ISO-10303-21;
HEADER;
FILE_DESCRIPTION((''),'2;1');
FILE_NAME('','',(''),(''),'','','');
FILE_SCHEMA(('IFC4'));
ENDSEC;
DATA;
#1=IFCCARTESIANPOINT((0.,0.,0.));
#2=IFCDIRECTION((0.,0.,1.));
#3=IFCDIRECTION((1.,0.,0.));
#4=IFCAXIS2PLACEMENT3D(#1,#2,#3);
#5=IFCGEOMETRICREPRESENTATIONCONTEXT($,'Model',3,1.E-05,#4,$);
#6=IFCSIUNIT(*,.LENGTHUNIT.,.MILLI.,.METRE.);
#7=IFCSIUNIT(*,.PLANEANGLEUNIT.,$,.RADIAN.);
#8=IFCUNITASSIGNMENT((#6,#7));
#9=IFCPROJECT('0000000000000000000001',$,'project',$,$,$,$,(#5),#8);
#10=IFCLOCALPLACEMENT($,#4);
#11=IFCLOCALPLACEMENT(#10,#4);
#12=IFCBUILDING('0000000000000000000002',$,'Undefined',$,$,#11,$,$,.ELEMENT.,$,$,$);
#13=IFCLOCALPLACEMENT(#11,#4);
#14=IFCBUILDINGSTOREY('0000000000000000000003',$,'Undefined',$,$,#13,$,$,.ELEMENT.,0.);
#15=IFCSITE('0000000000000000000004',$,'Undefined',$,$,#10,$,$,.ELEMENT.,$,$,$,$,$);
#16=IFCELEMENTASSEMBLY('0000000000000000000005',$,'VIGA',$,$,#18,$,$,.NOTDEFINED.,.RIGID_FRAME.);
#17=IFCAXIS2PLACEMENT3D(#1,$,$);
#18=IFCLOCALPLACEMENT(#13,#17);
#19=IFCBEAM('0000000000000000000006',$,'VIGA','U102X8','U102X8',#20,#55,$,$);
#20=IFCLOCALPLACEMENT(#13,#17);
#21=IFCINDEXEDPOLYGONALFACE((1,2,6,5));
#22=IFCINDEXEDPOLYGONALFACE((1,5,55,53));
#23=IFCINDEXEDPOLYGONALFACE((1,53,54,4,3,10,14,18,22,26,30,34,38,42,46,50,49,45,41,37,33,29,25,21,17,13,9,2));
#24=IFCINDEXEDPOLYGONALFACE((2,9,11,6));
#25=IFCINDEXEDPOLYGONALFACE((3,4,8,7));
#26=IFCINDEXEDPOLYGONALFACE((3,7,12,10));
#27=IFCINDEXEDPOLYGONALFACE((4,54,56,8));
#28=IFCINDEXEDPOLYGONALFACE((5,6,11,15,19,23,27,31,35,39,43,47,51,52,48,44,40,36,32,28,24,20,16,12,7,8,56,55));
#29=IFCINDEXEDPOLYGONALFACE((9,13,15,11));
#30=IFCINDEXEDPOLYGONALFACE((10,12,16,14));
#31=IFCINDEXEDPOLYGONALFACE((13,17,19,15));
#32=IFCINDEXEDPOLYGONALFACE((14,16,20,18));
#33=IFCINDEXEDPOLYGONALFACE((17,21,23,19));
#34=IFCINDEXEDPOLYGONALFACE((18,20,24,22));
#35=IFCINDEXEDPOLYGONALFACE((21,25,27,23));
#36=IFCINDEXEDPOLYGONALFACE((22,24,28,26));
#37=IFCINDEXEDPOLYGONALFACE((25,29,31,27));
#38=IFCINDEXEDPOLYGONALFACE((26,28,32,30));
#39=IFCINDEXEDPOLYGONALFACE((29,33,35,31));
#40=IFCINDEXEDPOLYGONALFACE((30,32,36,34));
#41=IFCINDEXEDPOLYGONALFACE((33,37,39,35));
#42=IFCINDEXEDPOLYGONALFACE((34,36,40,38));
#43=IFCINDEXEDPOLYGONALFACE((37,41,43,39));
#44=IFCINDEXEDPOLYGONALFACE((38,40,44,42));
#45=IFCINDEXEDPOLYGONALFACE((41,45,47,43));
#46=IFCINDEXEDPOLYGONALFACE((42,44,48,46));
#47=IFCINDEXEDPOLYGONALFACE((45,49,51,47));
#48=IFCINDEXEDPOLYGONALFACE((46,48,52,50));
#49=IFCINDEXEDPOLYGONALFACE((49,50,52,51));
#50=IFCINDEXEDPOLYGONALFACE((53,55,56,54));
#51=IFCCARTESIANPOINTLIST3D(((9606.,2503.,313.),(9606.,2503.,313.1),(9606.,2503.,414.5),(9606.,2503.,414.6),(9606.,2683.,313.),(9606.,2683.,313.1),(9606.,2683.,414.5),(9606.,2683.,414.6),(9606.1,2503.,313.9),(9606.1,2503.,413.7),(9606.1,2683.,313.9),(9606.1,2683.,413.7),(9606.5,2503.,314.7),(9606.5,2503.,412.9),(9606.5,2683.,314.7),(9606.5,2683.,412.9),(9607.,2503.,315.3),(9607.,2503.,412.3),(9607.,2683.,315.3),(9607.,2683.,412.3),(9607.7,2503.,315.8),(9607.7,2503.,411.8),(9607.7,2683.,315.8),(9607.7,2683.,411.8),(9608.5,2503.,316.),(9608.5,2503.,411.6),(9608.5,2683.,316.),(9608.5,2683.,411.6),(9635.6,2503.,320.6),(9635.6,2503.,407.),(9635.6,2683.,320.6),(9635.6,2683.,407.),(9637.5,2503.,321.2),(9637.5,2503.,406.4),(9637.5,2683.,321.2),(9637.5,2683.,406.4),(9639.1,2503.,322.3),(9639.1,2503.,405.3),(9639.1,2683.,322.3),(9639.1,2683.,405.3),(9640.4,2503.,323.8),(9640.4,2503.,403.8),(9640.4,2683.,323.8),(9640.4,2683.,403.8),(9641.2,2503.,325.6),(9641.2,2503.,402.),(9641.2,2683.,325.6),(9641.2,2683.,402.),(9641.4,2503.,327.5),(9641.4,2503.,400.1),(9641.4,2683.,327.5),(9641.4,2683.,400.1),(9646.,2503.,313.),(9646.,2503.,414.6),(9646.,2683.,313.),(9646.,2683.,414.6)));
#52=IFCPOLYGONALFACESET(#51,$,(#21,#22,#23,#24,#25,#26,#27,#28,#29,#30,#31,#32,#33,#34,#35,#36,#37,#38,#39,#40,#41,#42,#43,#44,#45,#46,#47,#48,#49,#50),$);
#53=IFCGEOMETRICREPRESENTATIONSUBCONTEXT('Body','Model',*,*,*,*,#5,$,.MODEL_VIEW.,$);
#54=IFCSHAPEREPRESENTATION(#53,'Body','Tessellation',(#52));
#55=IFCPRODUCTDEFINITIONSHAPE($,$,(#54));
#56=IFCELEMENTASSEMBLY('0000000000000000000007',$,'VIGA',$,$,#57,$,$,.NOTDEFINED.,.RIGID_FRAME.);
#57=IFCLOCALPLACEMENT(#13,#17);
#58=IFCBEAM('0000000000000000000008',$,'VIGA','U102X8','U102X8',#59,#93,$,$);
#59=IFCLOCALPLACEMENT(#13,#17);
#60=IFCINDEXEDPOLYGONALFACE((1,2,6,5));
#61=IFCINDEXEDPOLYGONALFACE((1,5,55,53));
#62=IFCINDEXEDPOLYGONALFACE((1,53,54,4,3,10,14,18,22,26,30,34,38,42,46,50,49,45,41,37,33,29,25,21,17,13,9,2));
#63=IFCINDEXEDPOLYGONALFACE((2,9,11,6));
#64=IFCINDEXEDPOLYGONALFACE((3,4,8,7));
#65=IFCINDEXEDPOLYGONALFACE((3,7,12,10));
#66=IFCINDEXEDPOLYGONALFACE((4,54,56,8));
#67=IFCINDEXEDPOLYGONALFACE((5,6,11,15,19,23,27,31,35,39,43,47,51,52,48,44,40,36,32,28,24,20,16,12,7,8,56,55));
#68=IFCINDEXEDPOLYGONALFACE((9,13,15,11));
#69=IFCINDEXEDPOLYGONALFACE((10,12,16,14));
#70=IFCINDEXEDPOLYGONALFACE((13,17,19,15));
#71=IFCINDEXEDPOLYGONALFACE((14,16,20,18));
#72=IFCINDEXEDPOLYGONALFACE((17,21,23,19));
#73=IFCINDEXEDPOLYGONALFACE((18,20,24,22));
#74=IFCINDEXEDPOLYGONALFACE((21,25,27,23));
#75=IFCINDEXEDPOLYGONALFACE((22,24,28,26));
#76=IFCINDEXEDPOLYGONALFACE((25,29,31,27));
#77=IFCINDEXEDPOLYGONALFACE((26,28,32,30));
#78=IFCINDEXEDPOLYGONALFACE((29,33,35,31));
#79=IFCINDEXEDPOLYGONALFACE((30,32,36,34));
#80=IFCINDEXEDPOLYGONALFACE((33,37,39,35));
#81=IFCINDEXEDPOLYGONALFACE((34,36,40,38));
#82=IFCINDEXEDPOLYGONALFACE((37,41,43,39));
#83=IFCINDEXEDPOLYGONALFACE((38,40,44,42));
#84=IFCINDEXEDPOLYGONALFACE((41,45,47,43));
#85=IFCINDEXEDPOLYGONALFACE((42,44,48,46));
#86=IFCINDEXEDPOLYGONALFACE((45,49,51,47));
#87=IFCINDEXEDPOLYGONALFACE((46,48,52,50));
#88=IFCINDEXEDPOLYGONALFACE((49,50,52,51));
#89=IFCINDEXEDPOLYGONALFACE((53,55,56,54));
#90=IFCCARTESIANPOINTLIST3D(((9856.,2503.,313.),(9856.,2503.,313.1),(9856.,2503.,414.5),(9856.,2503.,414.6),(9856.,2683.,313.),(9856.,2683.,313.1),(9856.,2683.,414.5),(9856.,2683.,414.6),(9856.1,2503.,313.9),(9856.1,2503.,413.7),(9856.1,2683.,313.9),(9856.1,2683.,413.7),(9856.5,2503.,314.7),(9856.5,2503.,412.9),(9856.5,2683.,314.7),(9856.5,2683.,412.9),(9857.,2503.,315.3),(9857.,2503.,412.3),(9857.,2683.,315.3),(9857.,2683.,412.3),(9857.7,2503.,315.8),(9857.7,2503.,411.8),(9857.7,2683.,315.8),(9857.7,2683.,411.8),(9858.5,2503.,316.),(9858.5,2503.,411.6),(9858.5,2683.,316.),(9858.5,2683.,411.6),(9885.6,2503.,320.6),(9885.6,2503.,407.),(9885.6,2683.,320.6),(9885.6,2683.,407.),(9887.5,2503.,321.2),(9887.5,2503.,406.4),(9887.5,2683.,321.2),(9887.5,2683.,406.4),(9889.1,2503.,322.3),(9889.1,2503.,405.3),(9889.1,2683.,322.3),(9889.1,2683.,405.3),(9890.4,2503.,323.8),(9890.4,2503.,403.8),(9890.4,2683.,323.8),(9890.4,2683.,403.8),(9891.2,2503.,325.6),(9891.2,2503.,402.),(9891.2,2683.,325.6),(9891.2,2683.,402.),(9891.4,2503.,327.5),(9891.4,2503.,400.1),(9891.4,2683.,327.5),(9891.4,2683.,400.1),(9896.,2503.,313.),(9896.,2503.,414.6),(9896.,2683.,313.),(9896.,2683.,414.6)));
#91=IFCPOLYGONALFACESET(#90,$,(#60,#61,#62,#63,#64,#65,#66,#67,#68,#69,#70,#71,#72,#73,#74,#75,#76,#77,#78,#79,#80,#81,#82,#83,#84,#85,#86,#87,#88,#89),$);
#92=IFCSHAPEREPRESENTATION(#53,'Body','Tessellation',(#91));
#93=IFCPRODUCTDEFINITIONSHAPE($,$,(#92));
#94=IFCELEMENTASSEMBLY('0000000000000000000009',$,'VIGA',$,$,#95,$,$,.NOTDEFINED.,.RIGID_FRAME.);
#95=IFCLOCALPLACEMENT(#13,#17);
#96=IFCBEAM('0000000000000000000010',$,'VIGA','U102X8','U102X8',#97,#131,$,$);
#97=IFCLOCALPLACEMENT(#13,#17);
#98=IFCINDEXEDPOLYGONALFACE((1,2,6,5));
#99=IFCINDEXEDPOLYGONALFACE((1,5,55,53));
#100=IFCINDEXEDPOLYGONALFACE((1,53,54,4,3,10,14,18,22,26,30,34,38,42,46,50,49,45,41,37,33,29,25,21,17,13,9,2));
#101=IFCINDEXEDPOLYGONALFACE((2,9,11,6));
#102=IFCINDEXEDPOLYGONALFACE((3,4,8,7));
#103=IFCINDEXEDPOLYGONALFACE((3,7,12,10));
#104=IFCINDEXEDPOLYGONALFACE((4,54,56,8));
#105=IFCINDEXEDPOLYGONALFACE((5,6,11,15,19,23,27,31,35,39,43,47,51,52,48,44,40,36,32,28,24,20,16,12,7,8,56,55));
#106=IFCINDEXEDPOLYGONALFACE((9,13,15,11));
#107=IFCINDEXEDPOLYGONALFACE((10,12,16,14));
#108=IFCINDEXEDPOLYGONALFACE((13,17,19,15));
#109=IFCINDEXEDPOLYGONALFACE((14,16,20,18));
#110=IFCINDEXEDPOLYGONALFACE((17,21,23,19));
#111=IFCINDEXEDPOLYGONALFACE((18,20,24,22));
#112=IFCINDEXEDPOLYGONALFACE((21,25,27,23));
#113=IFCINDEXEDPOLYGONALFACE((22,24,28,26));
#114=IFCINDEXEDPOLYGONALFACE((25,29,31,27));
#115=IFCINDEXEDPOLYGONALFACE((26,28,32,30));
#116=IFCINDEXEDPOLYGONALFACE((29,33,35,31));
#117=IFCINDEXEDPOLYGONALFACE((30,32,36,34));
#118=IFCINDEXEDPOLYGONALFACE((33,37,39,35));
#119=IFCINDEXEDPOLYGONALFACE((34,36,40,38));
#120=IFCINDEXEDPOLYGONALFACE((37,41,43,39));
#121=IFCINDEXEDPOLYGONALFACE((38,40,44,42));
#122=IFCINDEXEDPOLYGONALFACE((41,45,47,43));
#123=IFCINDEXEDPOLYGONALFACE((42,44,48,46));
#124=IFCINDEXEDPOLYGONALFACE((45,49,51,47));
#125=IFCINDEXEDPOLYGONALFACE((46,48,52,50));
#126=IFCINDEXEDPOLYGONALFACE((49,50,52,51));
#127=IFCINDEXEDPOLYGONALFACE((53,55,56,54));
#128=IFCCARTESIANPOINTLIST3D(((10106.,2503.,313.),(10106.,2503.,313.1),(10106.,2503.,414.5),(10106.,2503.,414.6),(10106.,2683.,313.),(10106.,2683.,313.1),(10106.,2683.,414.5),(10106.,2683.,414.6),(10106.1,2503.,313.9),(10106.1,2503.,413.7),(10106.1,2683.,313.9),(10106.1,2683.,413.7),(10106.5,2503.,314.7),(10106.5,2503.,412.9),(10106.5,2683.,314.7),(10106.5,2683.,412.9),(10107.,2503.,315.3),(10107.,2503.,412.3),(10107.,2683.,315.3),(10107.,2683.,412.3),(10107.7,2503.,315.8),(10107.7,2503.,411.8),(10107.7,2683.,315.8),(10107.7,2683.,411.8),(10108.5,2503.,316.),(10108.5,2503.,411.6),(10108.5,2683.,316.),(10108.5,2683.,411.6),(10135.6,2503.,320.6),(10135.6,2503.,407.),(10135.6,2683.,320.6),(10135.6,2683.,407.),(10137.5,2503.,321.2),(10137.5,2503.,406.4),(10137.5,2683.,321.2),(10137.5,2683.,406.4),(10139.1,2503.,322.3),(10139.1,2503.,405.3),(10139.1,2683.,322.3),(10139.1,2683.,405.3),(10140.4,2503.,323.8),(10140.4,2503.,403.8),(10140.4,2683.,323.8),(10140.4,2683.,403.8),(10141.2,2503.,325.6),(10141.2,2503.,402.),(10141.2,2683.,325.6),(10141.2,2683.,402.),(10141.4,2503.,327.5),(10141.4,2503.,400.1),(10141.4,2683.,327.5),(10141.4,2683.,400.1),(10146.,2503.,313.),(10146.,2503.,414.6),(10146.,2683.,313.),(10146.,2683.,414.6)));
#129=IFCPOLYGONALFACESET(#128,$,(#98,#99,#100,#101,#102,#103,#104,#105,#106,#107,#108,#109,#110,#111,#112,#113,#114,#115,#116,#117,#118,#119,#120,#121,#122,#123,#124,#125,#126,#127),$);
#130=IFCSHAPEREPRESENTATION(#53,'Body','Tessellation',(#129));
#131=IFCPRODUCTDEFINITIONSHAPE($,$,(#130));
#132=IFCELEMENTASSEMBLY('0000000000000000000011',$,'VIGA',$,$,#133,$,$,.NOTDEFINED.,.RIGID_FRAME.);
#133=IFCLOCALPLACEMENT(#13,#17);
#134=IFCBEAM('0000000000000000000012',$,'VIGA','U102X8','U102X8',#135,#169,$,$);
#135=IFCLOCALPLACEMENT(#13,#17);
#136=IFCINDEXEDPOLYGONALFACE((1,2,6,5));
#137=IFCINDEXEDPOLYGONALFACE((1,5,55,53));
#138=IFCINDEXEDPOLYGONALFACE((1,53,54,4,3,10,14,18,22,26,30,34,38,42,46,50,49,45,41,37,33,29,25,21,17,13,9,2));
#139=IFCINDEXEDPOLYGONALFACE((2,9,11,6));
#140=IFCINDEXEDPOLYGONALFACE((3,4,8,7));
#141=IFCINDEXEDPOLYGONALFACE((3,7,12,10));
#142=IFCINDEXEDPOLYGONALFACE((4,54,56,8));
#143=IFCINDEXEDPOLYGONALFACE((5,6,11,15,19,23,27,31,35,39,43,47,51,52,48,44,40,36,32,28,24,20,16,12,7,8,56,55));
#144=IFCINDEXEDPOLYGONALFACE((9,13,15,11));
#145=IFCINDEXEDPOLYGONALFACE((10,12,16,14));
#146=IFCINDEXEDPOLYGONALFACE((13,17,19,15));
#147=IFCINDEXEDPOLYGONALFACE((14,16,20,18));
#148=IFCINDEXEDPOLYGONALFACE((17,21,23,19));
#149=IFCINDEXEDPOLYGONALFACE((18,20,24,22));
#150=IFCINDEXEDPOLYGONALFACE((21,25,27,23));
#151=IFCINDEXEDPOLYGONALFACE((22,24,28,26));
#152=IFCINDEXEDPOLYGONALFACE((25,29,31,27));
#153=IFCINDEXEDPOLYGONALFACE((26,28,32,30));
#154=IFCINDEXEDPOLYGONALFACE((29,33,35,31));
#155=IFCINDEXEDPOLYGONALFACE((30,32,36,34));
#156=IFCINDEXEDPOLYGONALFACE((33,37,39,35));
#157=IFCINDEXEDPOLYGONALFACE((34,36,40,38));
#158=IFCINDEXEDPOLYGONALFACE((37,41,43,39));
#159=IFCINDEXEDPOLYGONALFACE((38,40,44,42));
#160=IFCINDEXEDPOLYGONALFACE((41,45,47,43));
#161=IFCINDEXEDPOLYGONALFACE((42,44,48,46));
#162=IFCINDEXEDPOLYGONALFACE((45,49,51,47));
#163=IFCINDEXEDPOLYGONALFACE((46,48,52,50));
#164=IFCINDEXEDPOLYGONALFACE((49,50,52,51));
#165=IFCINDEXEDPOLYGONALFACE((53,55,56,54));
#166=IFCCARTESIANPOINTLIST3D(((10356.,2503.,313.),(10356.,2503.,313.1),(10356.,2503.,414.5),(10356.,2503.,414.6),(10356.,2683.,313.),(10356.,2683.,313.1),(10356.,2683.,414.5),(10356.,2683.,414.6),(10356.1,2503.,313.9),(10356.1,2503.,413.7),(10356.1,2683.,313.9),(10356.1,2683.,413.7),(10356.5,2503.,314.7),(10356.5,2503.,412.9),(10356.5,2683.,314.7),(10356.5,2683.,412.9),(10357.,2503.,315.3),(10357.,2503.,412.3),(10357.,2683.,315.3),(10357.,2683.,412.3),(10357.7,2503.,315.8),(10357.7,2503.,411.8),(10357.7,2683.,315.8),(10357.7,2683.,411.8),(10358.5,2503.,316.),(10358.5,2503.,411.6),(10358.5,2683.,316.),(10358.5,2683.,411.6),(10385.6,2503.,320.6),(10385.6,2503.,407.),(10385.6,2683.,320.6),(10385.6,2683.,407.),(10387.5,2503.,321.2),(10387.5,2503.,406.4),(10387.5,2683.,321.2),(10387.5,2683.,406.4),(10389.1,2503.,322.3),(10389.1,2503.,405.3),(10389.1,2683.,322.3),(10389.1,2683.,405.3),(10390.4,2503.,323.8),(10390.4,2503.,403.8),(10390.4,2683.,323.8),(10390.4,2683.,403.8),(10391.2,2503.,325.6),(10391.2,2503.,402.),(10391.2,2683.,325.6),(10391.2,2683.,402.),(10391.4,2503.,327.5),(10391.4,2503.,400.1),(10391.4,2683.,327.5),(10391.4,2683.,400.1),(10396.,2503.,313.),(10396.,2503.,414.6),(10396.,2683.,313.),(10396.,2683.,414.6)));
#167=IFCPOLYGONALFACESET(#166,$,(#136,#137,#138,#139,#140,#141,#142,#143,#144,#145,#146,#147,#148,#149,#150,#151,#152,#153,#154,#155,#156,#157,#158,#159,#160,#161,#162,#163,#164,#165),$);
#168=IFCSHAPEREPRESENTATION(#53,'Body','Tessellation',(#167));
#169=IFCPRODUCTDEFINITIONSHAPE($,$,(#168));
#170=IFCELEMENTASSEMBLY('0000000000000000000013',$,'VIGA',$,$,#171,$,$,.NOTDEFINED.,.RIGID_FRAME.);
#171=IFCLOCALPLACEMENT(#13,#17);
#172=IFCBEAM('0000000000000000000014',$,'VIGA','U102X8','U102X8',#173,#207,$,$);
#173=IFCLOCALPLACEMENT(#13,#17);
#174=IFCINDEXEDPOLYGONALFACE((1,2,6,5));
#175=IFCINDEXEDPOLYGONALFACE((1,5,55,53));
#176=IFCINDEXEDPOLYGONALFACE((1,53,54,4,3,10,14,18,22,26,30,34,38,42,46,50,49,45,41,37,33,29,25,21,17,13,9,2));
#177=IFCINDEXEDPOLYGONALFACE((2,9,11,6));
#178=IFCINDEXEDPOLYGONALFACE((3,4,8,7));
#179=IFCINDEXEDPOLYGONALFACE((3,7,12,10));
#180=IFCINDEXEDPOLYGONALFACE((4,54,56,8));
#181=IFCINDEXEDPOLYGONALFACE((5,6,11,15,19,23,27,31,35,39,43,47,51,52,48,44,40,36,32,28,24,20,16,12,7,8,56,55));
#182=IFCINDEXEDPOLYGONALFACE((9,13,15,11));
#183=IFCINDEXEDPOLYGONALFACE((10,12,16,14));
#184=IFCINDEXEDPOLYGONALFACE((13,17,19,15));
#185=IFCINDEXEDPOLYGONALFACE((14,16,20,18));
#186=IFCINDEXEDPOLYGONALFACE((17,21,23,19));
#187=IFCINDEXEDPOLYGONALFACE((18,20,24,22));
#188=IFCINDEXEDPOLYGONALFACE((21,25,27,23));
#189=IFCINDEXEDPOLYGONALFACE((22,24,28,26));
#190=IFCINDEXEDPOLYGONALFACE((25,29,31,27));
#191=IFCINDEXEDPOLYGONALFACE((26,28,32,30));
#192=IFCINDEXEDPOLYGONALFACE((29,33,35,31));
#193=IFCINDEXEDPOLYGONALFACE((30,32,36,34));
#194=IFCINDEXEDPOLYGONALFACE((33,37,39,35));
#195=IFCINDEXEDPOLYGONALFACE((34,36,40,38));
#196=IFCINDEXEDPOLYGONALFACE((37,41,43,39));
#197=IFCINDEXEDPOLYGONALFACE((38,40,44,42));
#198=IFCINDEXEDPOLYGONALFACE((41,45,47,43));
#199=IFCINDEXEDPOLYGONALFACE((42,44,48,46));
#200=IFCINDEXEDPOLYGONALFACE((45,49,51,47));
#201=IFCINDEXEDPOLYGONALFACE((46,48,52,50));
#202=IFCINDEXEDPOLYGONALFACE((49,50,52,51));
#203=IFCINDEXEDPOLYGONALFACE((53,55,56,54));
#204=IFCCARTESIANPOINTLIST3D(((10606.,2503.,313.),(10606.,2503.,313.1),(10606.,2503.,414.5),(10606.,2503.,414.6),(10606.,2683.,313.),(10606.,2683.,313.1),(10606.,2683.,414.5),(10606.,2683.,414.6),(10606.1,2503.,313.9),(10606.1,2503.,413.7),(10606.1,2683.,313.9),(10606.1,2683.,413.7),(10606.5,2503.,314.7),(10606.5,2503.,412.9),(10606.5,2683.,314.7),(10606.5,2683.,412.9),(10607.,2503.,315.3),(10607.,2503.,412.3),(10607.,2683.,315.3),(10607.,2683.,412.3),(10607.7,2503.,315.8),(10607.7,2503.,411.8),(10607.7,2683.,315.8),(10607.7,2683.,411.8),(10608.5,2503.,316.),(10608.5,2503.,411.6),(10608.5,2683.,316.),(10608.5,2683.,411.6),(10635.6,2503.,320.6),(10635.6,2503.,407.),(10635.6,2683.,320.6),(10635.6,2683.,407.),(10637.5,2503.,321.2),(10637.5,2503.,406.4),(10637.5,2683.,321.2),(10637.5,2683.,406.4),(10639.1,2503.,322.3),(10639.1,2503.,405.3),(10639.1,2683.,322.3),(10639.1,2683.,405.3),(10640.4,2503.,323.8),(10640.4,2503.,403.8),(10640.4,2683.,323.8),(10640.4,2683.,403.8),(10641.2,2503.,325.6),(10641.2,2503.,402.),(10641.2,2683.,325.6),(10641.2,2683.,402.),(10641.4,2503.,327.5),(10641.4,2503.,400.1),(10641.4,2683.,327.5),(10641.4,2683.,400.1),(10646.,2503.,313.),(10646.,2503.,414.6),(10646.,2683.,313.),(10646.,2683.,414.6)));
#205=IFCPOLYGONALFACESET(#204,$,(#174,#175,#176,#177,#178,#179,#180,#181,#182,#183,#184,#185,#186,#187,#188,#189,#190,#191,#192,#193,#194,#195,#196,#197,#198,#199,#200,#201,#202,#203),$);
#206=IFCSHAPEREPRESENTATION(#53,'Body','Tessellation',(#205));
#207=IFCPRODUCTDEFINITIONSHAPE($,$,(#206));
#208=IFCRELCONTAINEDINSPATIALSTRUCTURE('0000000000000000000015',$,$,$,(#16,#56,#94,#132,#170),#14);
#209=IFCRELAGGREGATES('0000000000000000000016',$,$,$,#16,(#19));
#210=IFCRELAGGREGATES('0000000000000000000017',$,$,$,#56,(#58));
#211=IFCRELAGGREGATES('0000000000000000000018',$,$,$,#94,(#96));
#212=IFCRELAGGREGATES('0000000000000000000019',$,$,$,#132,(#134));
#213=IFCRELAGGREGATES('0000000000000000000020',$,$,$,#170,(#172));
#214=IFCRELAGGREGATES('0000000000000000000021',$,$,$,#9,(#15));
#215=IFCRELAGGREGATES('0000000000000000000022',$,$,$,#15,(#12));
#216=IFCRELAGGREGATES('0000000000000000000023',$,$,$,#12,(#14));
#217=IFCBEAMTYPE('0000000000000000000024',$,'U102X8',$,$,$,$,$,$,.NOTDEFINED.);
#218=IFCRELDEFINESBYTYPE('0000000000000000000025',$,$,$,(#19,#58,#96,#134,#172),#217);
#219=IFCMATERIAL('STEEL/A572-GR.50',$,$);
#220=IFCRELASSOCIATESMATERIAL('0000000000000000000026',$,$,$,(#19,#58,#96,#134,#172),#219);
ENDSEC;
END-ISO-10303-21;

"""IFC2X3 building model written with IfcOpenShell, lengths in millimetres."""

from ifc_helpers import new_model, si_unit, frame, origin_with_axes, origin_2d_with_axis, place, context, subcontext, project, spatial, u_section, extrude, material, type_object, element, aggregate, save


model = new_model("IFC2X3")

# Units and contexts
model_context = context("Model", 3, precision=1e-05, world=origin_with_axes())
body_context = subcontext(model_context, "Body", "Model", "MODEL_VIEW")
ifc_project = project(units=[si_unit("LENGTHUNIT", "METRE", prefix="MILLI"), si_unit("PLANEANGLEUNIT", "RADIAN")], contexts=[model_context])

# Site, building, storey
site_placement = place(None, origin_with_axes())
site = spatial("IfcSite", under=ifc_project, at=site_placement, Name="Undefined", CompositionType="ELEMENT")
building_placement = place(site_placement, origin_with_axes())
building = spatial("IfcBuilding", under=site, at=building_placement, Name="Undefined", CompositionType="ELEMENT")
storey_placement = place(building_placement, origin_with_axes())
storey = spatial("IfcBuildingStorey", under=building, at=storey_placement, Name="Undefined", CompositionType="ELEMENT", Elevation=0.0)

# Element assemblies, beams
ifc_material_1 = material(Name="STEEL/A572-GR.50")
beam_type = type_object("IfcBeamType", Name="U102X8", PredefinedType="NOTDEFINED")
assembly_1_placement = place(storey_placement, origin_with_axes())
assembly_1 = element("IfcElementAssembly", 1, at=assembly_1_placement, inside=storey, Name="VIGA", AssemblyPlace="NOTDEFINED", PredefinedType="RIGID_FRAME")
beam_1_placement = place(assembly_1_placement, frame((9626.0, 2683.0, 363.8), z_axis=(0.0, 0.0, 1.0), x_axis=(0.0, -1.0, 0.0)))
beam_1 = element("IfcBeam", 2, at=beam_1_placement, type_object=beam_type, material=ifc_material_1, Name="VIGA", Description="U102X8", ObjectType="U102X8", context=body_context, shape_type="SweptSolid", body=[
    extrude(u_section(Depth=101.6, FlangeWidth=40.0, WebThickness=4.6, FlangeThickness=6.0, FilletRadius=7.0, EdgeRadius=3.0, FlangeSlope=0.16839, at=origin_2d_with_axis()), frame((180.0, 0.0, 0.0), z_axis=(-1.0, 0.0, 0.0), x_axis=(0.0, -1.0, 0.0)), (0.0, 0.0, 1.0), 180.0),
])
aggregate(assembly_1, [beam_1])
assembly_2_placement = place(storey_placement, origin_with_axes())
assembly_2 = element("IfcElementAssembly", 3, at=assembly_2_placement, inside=storey, Name="VIGA", AssemblyPlace="NOTDEFINED", PredefinedType="RIGID_FRAME")
beam_2_placement = place(assembly_2_placement, frame((9876.0, 2683.0, 363.8), z_axis=(0.0, 0.0, 1.0), x_axis=(0.0, -1.0, 0.0)))
beam_2 = element("IfcBeam", 4, at=beam_2_placement, type_object=beam_type, material=ifc_material_1, Name="VIGA", Description="U102X8", ObjectType="U102X8", context=body_context, shape_type="SweptSolid", body=[
    extrude(u_section(Depth=101.6, FlangeWidth=40.0, WebThickness=4.6, FlangeThickness=6.0, FilletRadius=7.0, EdgeRadius=3.0, FlangeSlope=0.16839, at=origin_2d_with_axis()), frame((180.0, 0.0, 0.0), z_axis=(-1.0, 0.0, 0.0), x_axis=(0.0, -1.0, 0.0)), (0.0, 0.0, 1.0), 180.0),
])
aggregate(assembly_2, [beam_2])
assembly_3_placement = place(storey_placement, origin_with_axes())
assembly_3 = element("IfcElementAssembly", 5, at=assembly_3_placement, inside=storey, Name="VIGA", AssemblyPlace="NOTDEFINED", PredefinedType="RIGID_FRAME")
beam_3_placement = place(assembly_3_placement, frame((10126.0, 2683.0, 363.8), z_axis=(0.0, 0.0, 1.0), x_axis=(0.0, -1.0, 0.0)))
beam_3 = element("IfcBeam", 6, at=beam_3_placement, type_object=beam_type, material=ifc_material_1, Name="VIGA", Description="U102X8", ObjectType="U102X8", context=body_context, shape_type="SweptSolid", body=[
    extrude(u_section(Depth=101.6, FlangeWidth=40.0, WebThickness=4.6, FlangeThickness=6.0, FilletRadius=7.0, EdgeRadius=3.0, FlangeSlope=0.16839, at=origin_2d_with_axis()), frame((180.0, 0.0, 0.0), z_axis=(-1.0, 0.0, 0.0), x_axis=(0.0, -1.0, 0.0)), (0.0, 0.0, 1.0), 180.0),
])
aggregate(assembly_3, [beam_3])
assembly_4_placement = place(storey_placement, origin_with_axes())
assembly_4 = element("IfcElementAssembly", 7, at=assembly_4_placement, inside=storey, Name="VIGA", AssemblyPlace="NOTDEFINED", PredefinedType="RIGID_FRAME")
beam_4_placement = place(assembly_4_placement, frame((10376.0, 2683.0, 363.8), z_axis=(0.0, 0.0, 1.0), x_axis=(0.0, -1.0, 0.0)))
beam_4 = element("IfcBeam", 8, at=beam_4_placement, type_object=beam_type, material=ifc_material_1, Name="VIGA", Description="U102X8", ObjectType="U102X8", context=body_context, shape_type="SweptSolid", body=[
    extrude(u_section(Depth=101.6, FlangeWidth=40.0, WebThickness=4.6, FlangeThickness=6.0, FilletRadius=7.0, EdgeRadius=3.0, FlangeSlope=0.16839, at=origin_2d_with_axis()), frame((180.0, 0.0, 0.0), z_axis=(-1.0, 0.0, 0.0), x_axis=(0.0, -1.0, 0.0)), (0.0, 0.0, 1.0), 180.0),
])
aggregate(assembly_4, [beam_4])
assembly_5_placement = place(storey_placement, origin_with_axes())
assembly_5 = element("IfcElementAssembly", 9, at=assembly_5_placement, inside=storey, Name="VIGA", AssemblyPlace="NOTDEFINED", PredefinedType="RIGID_FRAME")
beam_5_placement = place(assembly_5_placement, frame((10626.0, 2683.0, 363.8), z_axis=(0.0, 0.0, 1.0), x_axis=(0.0, -1.0, 0.0)))
beam_5 = element("IfcBeam", 10, at=beam_5_placement, type_object=beam_type, material=ifc_material_1, Name="VIGA", Description="U102X8", ObjectType="U102X8", context=body_context, shape_type="SweptSolid", body=[
    extrude(u_section(Depth=101.6, FlangeWidth=40.0, WebThickness=4.6, FlangeThickness=6.0, FilletRadius=7.0, EdgeRadius=3.0, FlangeSlope=0.16839, at=origin_2d_with_axis()), frame((180.0, 0.0, 0.0), z_axis=(-1.0, 0.0, 0.0), x_axis=(0.0, -1.0, 0.0)), (0.0, 0.0, 1.0), 180.0),
])
aggregate(assembly_5, [beam_5])

save(model, "model.ifc")
